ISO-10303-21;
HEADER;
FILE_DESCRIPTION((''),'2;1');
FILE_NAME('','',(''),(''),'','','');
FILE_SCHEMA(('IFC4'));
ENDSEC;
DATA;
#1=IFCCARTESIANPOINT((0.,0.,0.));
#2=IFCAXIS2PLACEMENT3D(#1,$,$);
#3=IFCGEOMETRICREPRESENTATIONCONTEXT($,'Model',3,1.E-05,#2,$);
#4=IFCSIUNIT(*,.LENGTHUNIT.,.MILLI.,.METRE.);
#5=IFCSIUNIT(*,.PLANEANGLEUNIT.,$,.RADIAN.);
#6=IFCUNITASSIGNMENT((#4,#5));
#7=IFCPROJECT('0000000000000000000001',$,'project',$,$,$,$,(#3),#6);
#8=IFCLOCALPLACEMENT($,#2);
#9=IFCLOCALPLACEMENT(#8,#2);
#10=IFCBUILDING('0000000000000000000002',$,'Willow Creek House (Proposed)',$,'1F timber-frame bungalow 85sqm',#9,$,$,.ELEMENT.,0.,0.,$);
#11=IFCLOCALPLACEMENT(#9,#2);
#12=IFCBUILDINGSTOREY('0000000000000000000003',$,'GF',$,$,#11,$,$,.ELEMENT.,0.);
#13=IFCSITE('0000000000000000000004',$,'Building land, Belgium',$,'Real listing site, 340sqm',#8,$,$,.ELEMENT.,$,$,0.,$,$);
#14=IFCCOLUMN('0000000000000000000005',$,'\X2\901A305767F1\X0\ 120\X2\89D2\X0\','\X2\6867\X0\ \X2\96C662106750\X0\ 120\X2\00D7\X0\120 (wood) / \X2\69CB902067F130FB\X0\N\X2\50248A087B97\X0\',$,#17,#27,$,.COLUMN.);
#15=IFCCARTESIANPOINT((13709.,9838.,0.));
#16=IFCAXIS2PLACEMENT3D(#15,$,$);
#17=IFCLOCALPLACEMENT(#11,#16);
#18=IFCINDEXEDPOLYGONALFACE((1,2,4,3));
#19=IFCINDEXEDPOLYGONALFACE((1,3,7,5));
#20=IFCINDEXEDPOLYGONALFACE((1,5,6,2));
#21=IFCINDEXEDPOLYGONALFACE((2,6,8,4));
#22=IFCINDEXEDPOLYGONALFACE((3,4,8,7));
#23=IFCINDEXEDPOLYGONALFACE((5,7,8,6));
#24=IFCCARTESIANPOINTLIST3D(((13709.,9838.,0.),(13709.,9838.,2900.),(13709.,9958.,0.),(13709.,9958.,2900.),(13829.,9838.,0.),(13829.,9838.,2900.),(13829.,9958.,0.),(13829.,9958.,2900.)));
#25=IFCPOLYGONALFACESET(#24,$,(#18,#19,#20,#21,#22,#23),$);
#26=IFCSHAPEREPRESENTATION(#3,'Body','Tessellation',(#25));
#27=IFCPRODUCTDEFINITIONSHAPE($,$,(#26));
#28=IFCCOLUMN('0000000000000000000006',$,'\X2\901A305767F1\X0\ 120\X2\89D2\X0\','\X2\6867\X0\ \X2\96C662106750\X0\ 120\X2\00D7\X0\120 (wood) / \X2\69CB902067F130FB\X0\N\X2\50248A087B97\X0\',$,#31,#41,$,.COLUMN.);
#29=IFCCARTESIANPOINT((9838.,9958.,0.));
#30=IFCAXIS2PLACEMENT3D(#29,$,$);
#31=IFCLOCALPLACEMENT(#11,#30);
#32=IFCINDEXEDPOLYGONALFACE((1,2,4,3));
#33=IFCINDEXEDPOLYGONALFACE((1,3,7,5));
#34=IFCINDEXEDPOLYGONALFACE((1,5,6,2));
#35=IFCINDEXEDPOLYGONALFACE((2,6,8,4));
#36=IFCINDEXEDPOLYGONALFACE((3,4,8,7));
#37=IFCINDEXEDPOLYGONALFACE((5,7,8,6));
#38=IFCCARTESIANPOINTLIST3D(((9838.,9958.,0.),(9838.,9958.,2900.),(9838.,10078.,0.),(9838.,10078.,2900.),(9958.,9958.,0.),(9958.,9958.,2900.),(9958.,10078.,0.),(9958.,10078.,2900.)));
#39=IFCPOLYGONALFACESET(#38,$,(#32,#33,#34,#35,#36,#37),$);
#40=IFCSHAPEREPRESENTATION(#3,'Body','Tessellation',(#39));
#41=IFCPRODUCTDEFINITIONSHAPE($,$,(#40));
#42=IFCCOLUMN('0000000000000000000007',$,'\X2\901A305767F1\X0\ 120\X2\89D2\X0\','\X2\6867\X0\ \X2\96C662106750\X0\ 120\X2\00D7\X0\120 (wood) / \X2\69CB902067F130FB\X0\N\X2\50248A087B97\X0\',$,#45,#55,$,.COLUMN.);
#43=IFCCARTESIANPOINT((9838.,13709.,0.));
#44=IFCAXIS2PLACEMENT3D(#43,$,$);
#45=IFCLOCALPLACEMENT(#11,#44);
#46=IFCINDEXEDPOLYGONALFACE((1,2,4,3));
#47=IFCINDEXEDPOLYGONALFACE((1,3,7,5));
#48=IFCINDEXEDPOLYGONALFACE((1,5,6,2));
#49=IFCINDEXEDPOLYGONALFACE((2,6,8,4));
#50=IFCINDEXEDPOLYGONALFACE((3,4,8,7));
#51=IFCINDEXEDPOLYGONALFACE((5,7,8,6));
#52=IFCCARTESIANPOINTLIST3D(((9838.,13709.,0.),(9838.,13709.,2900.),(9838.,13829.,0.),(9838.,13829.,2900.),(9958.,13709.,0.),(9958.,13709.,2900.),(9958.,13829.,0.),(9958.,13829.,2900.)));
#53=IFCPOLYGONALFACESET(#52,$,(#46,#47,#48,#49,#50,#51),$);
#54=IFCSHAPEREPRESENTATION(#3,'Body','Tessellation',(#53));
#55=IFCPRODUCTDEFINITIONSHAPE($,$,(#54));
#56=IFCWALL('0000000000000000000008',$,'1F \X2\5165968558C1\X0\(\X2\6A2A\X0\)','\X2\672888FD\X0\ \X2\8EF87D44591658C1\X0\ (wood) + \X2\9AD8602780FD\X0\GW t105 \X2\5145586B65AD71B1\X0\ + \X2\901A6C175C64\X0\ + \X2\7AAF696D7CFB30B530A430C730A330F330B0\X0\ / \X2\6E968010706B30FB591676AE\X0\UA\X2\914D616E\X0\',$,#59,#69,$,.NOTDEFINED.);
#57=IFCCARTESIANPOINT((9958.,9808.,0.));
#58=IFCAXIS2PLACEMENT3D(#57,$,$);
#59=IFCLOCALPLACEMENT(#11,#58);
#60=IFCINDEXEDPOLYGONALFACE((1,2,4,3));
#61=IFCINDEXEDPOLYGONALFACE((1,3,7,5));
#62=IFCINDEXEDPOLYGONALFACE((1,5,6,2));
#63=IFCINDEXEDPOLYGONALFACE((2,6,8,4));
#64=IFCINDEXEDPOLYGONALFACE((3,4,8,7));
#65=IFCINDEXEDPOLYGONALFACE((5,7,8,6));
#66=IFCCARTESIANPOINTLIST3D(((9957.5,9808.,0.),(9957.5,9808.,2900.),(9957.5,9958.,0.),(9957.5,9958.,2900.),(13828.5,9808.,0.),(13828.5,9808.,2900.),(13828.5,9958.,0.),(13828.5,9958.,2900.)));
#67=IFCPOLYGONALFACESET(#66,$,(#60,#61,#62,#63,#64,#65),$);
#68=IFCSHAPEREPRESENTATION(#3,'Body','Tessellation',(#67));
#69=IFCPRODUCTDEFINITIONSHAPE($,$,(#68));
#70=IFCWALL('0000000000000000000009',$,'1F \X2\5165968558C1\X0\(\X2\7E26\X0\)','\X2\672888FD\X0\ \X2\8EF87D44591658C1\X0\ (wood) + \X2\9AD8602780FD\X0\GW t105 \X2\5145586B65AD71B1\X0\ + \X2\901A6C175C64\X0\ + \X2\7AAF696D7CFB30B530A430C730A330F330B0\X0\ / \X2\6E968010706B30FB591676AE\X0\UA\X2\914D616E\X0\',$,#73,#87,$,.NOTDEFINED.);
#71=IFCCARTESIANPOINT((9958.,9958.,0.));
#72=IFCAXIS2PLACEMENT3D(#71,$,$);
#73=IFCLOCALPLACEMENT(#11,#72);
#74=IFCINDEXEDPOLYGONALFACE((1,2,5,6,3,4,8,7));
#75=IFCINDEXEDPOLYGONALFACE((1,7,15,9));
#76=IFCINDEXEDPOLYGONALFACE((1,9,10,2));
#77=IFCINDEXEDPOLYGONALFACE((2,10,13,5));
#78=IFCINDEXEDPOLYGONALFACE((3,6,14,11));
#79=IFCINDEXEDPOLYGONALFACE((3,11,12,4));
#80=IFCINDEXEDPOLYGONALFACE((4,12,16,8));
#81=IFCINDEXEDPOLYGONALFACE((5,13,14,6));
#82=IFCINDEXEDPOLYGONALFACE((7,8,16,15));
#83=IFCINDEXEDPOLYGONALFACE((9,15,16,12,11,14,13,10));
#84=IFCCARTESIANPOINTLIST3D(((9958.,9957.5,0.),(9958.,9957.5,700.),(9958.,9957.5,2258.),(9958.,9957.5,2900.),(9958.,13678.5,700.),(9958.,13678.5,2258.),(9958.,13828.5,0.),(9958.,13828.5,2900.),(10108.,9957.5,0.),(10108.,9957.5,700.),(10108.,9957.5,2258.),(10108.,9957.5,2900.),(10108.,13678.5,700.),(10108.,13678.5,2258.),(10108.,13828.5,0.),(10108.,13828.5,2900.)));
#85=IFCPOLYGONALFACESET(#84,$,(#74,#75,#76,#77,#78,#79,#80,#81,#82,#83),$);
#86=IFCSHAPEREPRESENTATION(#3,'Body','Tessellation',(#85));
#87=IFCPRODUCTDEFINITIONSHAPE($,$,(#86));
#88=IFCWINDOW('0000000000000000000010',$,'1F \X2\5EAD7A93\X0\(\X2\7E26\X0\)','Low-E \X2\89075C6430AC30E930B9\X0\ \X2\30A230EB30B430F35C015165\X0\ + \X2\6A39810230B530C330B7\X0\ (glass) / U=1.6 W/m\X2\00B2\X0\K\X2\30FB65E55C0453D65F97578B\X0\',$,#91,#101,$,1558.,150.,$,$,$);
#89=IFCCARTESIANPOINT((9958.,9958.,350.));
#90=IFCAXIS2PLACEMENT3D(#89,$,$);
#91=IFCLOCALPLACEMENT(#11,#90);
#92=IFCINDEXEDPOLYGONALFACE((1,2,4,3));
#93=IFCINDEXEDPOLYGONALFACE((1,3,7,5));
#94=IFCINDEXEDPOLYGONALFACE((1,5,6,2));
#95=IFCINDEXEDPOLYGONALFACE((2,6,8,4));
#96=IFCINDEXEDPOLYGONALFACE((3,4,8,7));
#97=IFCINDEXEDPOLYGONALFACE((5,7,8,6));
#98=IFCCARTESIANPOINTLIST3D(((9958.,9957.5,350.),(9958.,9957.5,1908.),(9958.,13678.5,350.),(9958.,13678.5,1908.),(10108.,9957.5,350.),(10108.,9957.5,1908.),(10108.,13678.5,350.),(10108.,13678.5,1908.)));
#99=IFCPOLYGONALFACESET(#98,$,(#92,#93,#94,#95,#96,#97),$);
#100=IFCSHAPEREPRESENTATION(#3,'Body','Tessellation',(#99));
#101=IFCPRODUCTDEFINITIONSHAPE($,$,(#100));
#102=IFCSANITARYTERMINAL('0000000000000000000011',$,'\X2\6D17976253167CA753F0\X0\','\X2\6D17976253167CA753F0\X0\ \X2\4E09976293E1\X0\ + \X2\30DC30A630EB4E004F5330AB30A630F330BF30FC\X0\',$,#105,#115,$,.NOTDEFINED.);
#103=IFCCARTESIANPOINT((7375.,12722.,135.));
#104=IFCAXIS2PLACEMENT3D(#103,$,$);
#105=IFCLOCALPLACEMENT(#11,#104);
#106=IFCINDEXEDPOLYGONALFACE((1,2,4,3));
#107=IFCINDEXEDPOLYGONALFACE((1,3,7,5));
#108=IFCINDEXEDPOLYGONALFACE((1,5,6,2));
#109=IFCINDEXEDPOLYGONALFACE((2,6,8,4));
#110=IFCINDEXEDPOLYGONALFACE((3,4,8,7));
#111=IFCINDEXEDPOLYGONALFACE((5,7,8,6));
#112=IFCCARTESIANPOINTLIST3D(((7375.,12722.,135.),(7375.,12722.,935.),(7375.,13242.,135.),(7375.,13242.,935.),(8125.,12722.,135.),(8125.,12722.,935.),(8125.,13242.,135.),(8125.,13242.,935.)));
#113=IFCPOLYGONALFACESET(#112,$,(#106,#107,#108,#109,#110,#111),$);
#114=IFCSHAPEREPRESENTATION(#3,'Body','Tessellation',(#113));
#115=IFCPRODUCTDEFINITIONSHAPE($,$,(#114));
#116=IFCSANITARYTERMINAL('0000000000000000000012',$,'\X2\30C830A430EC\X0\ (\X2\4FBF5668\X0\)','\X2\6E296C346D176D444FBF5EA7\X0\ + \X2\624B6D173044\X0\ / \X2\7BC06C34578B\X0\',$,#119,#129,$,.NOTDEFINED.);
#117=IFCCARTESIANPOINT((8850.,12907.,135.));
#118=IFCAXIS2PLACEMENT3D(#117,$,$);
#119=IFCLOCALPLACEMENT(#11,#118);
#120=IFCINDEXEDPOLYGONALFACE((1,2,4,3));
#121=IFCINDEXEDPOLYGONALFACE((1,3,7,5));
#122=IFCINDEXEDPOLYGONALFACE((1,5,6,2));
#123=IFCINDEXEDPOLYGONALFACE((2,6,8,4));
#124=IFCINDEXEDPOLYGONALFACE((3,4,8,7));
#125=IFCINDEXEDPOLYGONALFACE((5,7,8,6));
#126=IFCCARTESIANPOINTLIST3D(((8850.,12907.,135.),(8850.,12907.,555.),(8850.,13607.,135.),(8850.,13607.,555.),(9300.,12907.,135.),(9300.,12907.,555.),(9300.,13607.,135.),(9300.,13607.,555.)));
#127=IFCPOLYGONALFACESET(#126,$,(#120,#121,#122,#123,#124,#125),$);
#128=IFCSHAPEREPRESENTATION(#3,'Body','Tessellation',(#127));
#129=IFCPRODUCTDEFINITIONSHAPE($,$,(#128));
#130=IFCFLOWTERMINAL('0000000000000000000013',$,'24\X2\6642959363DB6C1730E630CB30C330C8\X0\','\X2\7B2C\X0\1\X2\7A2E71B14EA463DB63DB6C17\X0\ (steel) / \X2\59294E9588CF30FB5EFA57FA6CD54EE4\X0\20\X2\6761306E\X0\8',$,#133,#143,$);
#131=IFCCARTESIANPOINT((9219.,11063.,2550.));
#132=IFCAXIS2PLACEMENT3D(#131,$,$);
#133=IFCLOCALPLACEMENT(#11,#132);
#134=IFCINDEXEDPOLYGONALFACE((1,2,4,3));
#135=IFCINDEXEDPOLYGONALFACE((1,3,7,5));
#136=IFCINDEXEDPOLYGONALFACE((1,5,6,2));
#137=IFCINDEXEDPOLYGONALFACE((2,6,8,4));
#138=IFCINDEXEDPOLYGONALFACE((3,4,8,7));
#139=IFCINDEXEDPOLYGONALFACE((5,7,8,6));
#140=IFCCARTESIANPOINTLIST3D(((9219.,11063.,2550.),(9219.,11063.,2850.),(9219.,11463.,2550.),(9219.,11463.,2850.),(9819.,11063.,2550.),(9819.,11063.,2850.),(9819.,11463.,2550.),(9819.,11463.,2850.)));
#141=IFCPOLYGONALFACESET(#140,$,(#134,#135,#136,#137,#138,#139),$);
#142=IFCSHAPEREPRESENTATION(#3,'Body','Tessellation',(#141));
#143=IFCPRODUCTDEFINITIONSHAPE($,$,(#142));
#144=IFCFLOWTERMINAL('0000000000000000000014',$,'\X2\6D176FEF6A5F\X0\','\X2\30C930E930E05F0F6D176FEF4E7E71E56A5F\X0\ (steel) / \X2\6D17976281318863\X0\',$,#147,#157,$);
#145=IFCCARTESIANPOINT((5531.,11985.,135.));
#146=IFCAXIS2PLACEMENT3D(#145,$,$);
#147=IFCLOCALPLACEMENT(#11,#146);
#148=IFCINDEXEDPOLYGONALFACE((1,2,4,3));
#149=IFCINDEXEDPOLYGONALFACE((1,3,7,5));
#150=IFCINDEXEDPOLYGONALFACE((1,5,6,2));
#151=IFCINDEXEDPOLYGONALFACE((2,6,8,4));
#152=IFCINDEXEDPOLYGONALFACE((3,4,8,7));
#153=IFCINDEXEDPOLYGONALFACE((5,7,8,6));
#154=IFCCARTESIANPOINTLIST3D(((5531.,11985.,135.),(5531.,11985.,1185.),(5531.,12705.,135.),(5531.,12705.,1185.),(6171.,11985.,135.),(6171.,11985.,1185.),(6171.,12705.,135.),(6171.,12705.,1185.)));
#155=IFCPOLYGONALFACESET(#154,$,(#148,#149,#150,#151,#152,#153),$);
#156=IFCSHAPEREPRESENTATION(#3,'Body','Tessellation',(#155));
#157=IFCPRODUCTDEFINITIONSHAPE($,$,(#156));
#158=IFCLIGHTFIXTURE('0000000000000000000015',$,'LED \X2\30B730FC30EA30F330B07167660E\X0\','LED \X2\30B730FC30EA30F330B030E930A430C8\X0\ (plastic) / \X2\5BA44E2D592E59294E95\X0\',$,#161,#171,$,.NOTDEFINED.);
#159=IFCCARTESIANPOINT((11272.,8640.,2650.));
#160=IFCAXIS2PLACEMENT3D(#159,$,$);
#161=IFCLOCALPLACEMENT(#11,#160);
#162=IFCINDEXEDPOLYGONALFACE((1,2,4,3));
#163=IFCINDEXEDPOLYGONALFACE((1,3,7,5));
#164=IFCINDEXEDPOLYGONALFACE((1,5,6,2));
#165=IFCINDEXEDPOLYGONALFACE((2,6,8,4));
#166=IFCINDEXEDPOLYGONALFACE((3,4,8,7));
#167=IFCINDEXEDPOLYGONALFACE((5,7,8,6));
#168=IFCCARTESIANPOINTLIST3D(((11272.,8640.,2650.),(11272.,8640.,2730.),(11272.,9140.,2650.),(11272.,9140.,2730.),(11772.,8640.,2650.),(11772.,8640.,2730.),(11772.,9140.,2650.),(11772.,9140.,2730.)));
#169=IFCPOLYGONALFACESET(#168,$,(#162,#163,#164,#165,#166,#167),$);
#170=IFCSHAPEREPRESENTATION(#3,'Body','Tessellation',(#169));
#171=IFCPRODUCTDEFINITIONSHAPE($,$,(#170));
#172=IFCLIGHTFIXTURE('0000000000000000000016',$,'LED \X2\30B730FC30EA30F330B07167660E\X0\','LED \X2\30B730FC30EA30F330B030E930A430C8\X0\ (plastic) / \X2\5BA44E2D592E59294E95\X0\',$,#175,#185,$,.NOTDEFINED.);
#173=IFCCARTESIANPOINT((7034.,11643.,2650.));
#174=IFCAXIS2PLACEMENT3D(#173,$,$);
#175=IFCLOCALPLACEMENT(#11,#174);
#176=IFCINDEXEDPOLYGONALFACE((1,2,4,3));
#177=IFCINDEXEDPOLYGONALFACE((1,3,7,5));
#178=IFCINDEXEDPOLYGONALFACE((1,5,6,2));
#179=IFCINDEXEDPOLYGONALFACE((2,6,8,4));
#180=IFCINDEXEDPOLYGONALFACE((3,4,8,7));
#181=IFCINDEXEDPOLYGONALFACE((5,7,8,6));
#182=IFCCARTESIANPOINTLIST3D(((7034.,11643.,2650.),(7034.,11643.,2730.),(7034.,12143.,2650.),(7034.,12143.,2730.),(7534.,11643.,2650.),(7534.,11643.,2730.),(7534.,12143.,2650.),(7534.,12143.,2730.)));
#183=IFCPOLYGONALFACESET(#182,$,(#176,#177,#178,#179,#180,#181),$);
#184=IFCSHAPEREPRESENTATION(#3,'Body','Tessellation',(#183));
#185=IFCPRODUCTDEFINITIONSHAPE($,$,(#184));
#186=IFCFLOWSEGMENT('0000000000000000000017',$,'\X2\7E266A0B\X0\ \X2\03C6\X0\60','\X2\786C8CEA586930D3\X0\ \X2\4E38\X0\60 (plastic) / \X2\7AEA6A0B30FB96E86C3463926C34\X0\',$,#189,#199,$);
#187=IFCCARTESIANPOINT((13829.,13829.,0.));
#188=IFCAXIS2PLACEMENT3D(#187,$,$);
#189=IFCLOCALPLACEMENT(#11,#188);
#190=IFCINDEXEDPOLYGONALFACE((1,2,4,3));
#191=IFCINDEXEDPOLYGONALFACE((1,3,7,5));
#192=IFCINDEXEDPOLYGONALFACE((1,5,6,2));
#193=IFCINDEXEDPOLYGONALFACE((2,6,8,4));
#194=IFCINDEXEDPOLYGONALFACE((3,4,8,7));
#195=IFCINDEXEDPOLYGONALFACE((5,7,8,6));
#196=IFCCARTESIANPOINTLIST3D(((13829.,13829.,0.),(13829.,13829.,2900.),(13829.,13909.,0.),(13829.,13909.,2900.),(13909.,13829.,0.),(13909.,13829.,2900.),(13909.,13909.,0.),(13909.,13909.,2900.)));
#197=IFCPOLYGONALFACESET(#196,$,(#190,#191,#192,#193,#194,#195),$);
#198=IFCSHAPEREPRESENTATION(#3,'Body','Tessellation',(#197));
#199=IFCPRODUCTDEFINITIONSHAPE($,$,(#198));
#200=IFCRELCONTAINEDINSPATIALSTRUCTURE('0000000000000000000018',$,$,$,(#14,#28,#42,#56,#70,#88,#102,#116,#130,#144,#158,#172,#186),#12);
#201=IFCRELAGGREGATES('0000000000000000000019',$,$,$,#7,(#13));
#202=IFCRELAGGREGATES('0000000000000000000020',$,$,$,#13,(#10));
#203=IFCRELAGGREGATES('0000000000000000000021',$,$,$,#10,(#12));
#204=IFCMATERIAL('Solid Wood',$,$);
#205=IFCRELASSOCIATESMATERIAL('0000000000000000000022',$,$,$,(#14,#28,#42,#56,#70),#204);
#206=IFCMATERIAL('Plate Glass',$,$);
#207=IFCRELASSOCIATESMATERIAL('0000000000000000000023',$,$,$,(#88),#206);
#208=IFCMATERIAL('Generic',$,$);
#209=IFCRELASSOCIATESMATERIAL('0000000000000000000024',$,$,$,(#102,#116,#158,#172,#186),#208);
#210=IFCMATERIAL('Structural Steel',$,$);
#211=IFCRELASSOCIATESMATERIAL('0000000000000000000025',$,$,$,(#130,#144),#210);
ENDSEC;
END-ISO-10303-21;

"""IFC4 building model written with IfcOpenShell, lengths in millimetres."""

from ifc_helpers import new_model, si_unit, frame, frame_2d, origin, place, context, project, spatial, rectangle, extrude, material, element, fill, save


model = new_model("IFC4")

# Units and contexts
model_context = context("Model", 3, precision=1e-05, world=origin())
ifc_project = project(units=[si_unit("LENGTHUNIT", "METRE", prefix="MILLI"), si_unit("PLANEANGLEUNIT", "RADIAN")], contexts=[model_context])

# Site, building, storey
site_placement = place(None, origin())
site = spatial("IfcSite", under=ifc_project, at=site_placement, Name="Building land, Belgium", ObjectType="Real listing site, 340sqm", CompositionType="ELEMENT", RefElevation=0.0)
building_placement = place(site_placement, origin())
building = spatial("IfcBuilding", under=site, at=building_placement, Name="Willow Creek House (Proposed)", ObjectType="1F timber-frame bungalow 85sqm", CompositionType="ELEMENT", ElevationOfRefHeight=0.0, ElevationOfTerrain=0.0)
storey_placement = place(building_placement, origin())
storey = spatial("IfcBuildingStorey", under=building, at=storey_placement, Name="GF", CompositionType="ELEMENT", Elevation=0.0)

# Columns
ifc_material_1 = material(Name="Solid Wood")
column_1_placement = place(storey_placement, frame((13709.0, 9838.0, 0.0)))
element("IfcColumn", 1, at=column_1_placement, inside=storey, material=ifc_material_1, Name="通し柱 120角", Description="桧 集成材 120×120 (wood) / 構造柱・N値計算", PredefinedType="COLUMN", context=model_context, shape_type="SweptSolid", body=[
    extrude(rectangle(XDim=120.0, YDim=120.0, at=frame_2d((60.0, 60.0))), frame((13709.0, 9838.0, 0.0)), (0.0, 0.0, 1.0), 2900.0),
])
column_2_placement = place(storey_placement, frame((9838.0, 9958.0, 0.0)))
element("IfcColumn", 2, at=column_2_placement, inside=storey, material=ifc_material_1, Name="通し柱 120角", Description="桧 集成材 120×120 (wood) / 構造柱・N値計算", PredefinedType="COLUMN", context=model_context, shape_type="SweptSolid", body=[
    extrude(rectangle(XDim=120.0, YDim=120.0, at=frame_2d((60.0, 60.0))), frame((9838.0, 9958.0, 0.0)), (0.0, 0.0, 1.0), 2900.0),
])
column_3_placement = place(storey_placement, frame((9838.0, 13709.0, 0.0)))
element("IfcColumn", 3, at=column_3_placement, inside=storey, material=ifc_material_1, Name="通し柱 120角", Description="桧 集成材 120×120 (wood) / 構造柱・N値計算", PredefinedType="COLUMN", context=model_context, shape_type="SweptSolid", body=[
    extrude(rectangle(XDim=120.0, YDim=120.0, at=frame_2d((60.0, 60.0))), frame((9838.0, 13709.0, 0.0)), (0.0, 0.0, 1.0), 2900.0),
])

# Wall
wall_1_placement = place(storey_placement, frame((9958.0, 9808.0, 0.0)))
element("IfcWall", 4, at=wall_1_placement, inside=storey, material=ifc_material_1, Name="1F 入隅壁(横)", Description="木製 軸組外壁 (wood) + 高性能GW t105 充填断熱 + 通気層 + 窯業系サイディング / 準耐火・外皮UA配慮", PredefinedType="NOTDEFINED", context=model_context, shape_type="SweptSolid", body=[
    extrude(rectangle(XDim=3871.0, YDim=150.0, at=frame_2d((1935.0, 75.0))), frame((9958.0, 9808.0, 0.0)), (0.0, 0.0, 1.0), 2900.0),
])

# Wall, opening, window
wall_2_placement = place(storey_placement, frame((9958.0, 9958.0, 0.0)))
wall_2 = element("IfcWall", 5, at=wall_2_placement, inside=storey, material=ifc_material_1, Name="1F 入隅壁(縦)", Description="木製 軸組外壁 (wood) + 高性能GW t105 充填断熱 + 通気層 + 窯業系サイディング / 準耐火・外皮UA配慮", PredefinedType="NOTDEFINED", context=model_context, shape_type="SweptSolid", body=[
    extrude(rectangle(XDim=150.0, YDim=3871.0, at=frame_2d((75.0, 1935.0))), frame((9958.0, 9958.0, 0.0)), (0.0, 0.0, 1.0), 2900.0),
])
opening_placement = place(storey_placement, frame((9958.0, 9958.0, 350.0)))
opening = element("IfcOpeningElement", 6, at=opening_placement, cuts=wall_2, PredefinedType="NOTDEFINED", context=model_context, shape_type="SweptSolid", body=[
    extrude(rectangle(XDim=150.0, YDim=3721.0, at=frame_2d((75.0, 1860.0))), frame((9958.0, 9958.0, 350.0)), (0.0, 0.0, 1.0), 1558.0),
])
ifc_material_2 = material(Name="Plate Glass")
window_placement = place(storey_placement, frame((9958.0, 9958.0, 350.0)))
window = element("IfcWindow", 7, at=window_placement, inside=storey, material=ifc_material_2, Name="1F 庭窓(縦)", Description="Low-E 複層ガラス アルゴン封入 + 樹脂サッシ (glass) / U=1.6 W/m²K・日射取得型", OverallHeight=1558.0, OverallWidth=150.0, context=model_context, shape_type="SweptSolid", body=[
    extrude(rectangle(XDim=150.0, YDim=3721.0, at=frame_2d((75.0, 1860.0))), frame((9958.0, 9958.0, 350.0)), (0.0, 0.0, 1.0), 1558.0),
])
fill(opening, window)

# Sanitary terminals
ifc_material_3 = material(Name="Generic")
sanitary_terminal_1_placement = place(storey_placement, frame((7375.0, 12722.0, 135.0)))
element("IfcSanitaryTerminal", 8, at=sanitary_terminal_1_placement, inside=storey, material=ifc_material_3, Name="洗面化粧台", Description="洗面化粧台 三面鏡 + ボウル一体カウンター", PredefinedType="NOTDEFINED", context=model_context, shape_type="SweptSolid", body=[
    extrude(rectangle(XDim=750.0, YDim=520.0, at=frame_2d((375.0, 260.0))), frame((7375.0, 12722.0, 135.0)), (0.0, 0.0, 1.0), 800.0),
])
sanitary_terminal_2_placement = place(storey_placement, frame((8850.0, 12907.0, 135.0)))
element("IfcSanitaryTerminal", 9, at=sanitary_terminal_2_placement, inside=storey, material=ifc_material_3, Name="トイレ (便器)", Description="温水洗浄便座 + 手洗い / 節水型", PredefinedType="NOTDEFINED", context=model_context, shape_type="SweptSolid", body=[
    extrude(rectangle(XDim=450.0, YDim=700.0, at=frame_2d((225.0, 350.0))), frame((8850.0, 12907.0, 135.0)), (0.0, 0.0, 1.0), 420.0),
])

# Flow terminals
ifc_material_4 = material(Name="Structural Steel")
flow_terminal_1_placement = place(storey_placement, frame((9219.0, 11063.0, 2550.0)))
element("IfcFlowTerminal", 10, at=flow_terminal_1_placement, inside=storey, material=ifc_material_4, Name="24時間換気ユニット", Description="第1種熱交換換気 (steel) / 天井裏・建基法令20条の8", context=model_context, shape_type="SweptSolid", body=[
    extrude(rectangle(XDim=600.0, YDim=400.0, at=frame_2d((300.0, 200.0))), frame((9219.0, 11063.0, 2550.0)), (0.0, 0.0, 1.0), 300.0),
])
flow_terminal_2_placement = place(storey_placement, frame((5531.0, 11985.0, 135.0)))
element("IfcFlowTerminal", 11, at=flow_terminal_2_placement, inside=storey, material=ifc_material_4, Name="洗濯機", Description="ドラム式洗濯乾燥機 (steel) / 洗面脱衣", context=model_context, shape_type="SweptSolid", body=[
    extrude(rectangle(XDim=640.0, YDim=720.0, at=frame_2d((320.0, 360.0))), frame((5531.0, 11985.0, 135.0)), (0.0, 0.0, 1.0), 1050.0),
])

# Light fixtures
light_fixture_1_placement = place(storey_placement, frame((11272.0, 8640.0, 2650.0)))
element("IfcLightFixture", 12, at=light_fixture_1_placement, inside=storey, material=ifc_material_3, Name="LED シーリング照明", Description="LED シーリングライト (plastic) / 室中央天井", PredefinedType="NOTDEFINED", context=model_context, shape_type="SweptSolid", body=[
    extrude(rectangle(XDim=500.0, YDim=500.0, at=frame_2d((250.0, 250.0))), frame((11272.0, 8640.0, 2650.0)), (0.0, 0.0, 1.0), 80.0),
])
light_fixture_2_placement = place(storey_placement, frame((7034.0, 11643.0, 2650.0)))
element("IfcLightFixture", 13, at=light_fixture_2_placement, inside=storey, material=ifc_material_3, Name="LED シーリング照明", Description="LED シーリングライト (plastic) / 室中央天井", PredefinedType="NOTDEFINED", context=model_context, shape_type="SweptSolid", body=[
    extrude(rectangle(XDim=500.0, YDim=500.0, at=frame_2d((250.0, 250.0))), frame((7034.0, 11643.0, 2650.0)), (0.0, 0.0, 1.0), 80.0),
])

# Flow segment
flow_segment_placement = place(storey_placement, frame((13829.0, 13829.0, 0.0)))
element("IfcFlowSegment", 14, at=flow_segment_placement, inside=storey, material=ifc_material_3, Name="縦樋 φ60", Description="硬質塩ビ 丸60 (plastic) / 竪樋・雨水排水", context=model_context, shape_type="SweptSolid", body=[
    extrude(rectangle(XDim=80.0, YDim=80.0, at=frame_2d((40.0, 40.0))), frame((13829.0, 13829.0, 0.0)), (0.0, 0.0, 1.0), 2900.0),
])

save(model, "model.ifc")
